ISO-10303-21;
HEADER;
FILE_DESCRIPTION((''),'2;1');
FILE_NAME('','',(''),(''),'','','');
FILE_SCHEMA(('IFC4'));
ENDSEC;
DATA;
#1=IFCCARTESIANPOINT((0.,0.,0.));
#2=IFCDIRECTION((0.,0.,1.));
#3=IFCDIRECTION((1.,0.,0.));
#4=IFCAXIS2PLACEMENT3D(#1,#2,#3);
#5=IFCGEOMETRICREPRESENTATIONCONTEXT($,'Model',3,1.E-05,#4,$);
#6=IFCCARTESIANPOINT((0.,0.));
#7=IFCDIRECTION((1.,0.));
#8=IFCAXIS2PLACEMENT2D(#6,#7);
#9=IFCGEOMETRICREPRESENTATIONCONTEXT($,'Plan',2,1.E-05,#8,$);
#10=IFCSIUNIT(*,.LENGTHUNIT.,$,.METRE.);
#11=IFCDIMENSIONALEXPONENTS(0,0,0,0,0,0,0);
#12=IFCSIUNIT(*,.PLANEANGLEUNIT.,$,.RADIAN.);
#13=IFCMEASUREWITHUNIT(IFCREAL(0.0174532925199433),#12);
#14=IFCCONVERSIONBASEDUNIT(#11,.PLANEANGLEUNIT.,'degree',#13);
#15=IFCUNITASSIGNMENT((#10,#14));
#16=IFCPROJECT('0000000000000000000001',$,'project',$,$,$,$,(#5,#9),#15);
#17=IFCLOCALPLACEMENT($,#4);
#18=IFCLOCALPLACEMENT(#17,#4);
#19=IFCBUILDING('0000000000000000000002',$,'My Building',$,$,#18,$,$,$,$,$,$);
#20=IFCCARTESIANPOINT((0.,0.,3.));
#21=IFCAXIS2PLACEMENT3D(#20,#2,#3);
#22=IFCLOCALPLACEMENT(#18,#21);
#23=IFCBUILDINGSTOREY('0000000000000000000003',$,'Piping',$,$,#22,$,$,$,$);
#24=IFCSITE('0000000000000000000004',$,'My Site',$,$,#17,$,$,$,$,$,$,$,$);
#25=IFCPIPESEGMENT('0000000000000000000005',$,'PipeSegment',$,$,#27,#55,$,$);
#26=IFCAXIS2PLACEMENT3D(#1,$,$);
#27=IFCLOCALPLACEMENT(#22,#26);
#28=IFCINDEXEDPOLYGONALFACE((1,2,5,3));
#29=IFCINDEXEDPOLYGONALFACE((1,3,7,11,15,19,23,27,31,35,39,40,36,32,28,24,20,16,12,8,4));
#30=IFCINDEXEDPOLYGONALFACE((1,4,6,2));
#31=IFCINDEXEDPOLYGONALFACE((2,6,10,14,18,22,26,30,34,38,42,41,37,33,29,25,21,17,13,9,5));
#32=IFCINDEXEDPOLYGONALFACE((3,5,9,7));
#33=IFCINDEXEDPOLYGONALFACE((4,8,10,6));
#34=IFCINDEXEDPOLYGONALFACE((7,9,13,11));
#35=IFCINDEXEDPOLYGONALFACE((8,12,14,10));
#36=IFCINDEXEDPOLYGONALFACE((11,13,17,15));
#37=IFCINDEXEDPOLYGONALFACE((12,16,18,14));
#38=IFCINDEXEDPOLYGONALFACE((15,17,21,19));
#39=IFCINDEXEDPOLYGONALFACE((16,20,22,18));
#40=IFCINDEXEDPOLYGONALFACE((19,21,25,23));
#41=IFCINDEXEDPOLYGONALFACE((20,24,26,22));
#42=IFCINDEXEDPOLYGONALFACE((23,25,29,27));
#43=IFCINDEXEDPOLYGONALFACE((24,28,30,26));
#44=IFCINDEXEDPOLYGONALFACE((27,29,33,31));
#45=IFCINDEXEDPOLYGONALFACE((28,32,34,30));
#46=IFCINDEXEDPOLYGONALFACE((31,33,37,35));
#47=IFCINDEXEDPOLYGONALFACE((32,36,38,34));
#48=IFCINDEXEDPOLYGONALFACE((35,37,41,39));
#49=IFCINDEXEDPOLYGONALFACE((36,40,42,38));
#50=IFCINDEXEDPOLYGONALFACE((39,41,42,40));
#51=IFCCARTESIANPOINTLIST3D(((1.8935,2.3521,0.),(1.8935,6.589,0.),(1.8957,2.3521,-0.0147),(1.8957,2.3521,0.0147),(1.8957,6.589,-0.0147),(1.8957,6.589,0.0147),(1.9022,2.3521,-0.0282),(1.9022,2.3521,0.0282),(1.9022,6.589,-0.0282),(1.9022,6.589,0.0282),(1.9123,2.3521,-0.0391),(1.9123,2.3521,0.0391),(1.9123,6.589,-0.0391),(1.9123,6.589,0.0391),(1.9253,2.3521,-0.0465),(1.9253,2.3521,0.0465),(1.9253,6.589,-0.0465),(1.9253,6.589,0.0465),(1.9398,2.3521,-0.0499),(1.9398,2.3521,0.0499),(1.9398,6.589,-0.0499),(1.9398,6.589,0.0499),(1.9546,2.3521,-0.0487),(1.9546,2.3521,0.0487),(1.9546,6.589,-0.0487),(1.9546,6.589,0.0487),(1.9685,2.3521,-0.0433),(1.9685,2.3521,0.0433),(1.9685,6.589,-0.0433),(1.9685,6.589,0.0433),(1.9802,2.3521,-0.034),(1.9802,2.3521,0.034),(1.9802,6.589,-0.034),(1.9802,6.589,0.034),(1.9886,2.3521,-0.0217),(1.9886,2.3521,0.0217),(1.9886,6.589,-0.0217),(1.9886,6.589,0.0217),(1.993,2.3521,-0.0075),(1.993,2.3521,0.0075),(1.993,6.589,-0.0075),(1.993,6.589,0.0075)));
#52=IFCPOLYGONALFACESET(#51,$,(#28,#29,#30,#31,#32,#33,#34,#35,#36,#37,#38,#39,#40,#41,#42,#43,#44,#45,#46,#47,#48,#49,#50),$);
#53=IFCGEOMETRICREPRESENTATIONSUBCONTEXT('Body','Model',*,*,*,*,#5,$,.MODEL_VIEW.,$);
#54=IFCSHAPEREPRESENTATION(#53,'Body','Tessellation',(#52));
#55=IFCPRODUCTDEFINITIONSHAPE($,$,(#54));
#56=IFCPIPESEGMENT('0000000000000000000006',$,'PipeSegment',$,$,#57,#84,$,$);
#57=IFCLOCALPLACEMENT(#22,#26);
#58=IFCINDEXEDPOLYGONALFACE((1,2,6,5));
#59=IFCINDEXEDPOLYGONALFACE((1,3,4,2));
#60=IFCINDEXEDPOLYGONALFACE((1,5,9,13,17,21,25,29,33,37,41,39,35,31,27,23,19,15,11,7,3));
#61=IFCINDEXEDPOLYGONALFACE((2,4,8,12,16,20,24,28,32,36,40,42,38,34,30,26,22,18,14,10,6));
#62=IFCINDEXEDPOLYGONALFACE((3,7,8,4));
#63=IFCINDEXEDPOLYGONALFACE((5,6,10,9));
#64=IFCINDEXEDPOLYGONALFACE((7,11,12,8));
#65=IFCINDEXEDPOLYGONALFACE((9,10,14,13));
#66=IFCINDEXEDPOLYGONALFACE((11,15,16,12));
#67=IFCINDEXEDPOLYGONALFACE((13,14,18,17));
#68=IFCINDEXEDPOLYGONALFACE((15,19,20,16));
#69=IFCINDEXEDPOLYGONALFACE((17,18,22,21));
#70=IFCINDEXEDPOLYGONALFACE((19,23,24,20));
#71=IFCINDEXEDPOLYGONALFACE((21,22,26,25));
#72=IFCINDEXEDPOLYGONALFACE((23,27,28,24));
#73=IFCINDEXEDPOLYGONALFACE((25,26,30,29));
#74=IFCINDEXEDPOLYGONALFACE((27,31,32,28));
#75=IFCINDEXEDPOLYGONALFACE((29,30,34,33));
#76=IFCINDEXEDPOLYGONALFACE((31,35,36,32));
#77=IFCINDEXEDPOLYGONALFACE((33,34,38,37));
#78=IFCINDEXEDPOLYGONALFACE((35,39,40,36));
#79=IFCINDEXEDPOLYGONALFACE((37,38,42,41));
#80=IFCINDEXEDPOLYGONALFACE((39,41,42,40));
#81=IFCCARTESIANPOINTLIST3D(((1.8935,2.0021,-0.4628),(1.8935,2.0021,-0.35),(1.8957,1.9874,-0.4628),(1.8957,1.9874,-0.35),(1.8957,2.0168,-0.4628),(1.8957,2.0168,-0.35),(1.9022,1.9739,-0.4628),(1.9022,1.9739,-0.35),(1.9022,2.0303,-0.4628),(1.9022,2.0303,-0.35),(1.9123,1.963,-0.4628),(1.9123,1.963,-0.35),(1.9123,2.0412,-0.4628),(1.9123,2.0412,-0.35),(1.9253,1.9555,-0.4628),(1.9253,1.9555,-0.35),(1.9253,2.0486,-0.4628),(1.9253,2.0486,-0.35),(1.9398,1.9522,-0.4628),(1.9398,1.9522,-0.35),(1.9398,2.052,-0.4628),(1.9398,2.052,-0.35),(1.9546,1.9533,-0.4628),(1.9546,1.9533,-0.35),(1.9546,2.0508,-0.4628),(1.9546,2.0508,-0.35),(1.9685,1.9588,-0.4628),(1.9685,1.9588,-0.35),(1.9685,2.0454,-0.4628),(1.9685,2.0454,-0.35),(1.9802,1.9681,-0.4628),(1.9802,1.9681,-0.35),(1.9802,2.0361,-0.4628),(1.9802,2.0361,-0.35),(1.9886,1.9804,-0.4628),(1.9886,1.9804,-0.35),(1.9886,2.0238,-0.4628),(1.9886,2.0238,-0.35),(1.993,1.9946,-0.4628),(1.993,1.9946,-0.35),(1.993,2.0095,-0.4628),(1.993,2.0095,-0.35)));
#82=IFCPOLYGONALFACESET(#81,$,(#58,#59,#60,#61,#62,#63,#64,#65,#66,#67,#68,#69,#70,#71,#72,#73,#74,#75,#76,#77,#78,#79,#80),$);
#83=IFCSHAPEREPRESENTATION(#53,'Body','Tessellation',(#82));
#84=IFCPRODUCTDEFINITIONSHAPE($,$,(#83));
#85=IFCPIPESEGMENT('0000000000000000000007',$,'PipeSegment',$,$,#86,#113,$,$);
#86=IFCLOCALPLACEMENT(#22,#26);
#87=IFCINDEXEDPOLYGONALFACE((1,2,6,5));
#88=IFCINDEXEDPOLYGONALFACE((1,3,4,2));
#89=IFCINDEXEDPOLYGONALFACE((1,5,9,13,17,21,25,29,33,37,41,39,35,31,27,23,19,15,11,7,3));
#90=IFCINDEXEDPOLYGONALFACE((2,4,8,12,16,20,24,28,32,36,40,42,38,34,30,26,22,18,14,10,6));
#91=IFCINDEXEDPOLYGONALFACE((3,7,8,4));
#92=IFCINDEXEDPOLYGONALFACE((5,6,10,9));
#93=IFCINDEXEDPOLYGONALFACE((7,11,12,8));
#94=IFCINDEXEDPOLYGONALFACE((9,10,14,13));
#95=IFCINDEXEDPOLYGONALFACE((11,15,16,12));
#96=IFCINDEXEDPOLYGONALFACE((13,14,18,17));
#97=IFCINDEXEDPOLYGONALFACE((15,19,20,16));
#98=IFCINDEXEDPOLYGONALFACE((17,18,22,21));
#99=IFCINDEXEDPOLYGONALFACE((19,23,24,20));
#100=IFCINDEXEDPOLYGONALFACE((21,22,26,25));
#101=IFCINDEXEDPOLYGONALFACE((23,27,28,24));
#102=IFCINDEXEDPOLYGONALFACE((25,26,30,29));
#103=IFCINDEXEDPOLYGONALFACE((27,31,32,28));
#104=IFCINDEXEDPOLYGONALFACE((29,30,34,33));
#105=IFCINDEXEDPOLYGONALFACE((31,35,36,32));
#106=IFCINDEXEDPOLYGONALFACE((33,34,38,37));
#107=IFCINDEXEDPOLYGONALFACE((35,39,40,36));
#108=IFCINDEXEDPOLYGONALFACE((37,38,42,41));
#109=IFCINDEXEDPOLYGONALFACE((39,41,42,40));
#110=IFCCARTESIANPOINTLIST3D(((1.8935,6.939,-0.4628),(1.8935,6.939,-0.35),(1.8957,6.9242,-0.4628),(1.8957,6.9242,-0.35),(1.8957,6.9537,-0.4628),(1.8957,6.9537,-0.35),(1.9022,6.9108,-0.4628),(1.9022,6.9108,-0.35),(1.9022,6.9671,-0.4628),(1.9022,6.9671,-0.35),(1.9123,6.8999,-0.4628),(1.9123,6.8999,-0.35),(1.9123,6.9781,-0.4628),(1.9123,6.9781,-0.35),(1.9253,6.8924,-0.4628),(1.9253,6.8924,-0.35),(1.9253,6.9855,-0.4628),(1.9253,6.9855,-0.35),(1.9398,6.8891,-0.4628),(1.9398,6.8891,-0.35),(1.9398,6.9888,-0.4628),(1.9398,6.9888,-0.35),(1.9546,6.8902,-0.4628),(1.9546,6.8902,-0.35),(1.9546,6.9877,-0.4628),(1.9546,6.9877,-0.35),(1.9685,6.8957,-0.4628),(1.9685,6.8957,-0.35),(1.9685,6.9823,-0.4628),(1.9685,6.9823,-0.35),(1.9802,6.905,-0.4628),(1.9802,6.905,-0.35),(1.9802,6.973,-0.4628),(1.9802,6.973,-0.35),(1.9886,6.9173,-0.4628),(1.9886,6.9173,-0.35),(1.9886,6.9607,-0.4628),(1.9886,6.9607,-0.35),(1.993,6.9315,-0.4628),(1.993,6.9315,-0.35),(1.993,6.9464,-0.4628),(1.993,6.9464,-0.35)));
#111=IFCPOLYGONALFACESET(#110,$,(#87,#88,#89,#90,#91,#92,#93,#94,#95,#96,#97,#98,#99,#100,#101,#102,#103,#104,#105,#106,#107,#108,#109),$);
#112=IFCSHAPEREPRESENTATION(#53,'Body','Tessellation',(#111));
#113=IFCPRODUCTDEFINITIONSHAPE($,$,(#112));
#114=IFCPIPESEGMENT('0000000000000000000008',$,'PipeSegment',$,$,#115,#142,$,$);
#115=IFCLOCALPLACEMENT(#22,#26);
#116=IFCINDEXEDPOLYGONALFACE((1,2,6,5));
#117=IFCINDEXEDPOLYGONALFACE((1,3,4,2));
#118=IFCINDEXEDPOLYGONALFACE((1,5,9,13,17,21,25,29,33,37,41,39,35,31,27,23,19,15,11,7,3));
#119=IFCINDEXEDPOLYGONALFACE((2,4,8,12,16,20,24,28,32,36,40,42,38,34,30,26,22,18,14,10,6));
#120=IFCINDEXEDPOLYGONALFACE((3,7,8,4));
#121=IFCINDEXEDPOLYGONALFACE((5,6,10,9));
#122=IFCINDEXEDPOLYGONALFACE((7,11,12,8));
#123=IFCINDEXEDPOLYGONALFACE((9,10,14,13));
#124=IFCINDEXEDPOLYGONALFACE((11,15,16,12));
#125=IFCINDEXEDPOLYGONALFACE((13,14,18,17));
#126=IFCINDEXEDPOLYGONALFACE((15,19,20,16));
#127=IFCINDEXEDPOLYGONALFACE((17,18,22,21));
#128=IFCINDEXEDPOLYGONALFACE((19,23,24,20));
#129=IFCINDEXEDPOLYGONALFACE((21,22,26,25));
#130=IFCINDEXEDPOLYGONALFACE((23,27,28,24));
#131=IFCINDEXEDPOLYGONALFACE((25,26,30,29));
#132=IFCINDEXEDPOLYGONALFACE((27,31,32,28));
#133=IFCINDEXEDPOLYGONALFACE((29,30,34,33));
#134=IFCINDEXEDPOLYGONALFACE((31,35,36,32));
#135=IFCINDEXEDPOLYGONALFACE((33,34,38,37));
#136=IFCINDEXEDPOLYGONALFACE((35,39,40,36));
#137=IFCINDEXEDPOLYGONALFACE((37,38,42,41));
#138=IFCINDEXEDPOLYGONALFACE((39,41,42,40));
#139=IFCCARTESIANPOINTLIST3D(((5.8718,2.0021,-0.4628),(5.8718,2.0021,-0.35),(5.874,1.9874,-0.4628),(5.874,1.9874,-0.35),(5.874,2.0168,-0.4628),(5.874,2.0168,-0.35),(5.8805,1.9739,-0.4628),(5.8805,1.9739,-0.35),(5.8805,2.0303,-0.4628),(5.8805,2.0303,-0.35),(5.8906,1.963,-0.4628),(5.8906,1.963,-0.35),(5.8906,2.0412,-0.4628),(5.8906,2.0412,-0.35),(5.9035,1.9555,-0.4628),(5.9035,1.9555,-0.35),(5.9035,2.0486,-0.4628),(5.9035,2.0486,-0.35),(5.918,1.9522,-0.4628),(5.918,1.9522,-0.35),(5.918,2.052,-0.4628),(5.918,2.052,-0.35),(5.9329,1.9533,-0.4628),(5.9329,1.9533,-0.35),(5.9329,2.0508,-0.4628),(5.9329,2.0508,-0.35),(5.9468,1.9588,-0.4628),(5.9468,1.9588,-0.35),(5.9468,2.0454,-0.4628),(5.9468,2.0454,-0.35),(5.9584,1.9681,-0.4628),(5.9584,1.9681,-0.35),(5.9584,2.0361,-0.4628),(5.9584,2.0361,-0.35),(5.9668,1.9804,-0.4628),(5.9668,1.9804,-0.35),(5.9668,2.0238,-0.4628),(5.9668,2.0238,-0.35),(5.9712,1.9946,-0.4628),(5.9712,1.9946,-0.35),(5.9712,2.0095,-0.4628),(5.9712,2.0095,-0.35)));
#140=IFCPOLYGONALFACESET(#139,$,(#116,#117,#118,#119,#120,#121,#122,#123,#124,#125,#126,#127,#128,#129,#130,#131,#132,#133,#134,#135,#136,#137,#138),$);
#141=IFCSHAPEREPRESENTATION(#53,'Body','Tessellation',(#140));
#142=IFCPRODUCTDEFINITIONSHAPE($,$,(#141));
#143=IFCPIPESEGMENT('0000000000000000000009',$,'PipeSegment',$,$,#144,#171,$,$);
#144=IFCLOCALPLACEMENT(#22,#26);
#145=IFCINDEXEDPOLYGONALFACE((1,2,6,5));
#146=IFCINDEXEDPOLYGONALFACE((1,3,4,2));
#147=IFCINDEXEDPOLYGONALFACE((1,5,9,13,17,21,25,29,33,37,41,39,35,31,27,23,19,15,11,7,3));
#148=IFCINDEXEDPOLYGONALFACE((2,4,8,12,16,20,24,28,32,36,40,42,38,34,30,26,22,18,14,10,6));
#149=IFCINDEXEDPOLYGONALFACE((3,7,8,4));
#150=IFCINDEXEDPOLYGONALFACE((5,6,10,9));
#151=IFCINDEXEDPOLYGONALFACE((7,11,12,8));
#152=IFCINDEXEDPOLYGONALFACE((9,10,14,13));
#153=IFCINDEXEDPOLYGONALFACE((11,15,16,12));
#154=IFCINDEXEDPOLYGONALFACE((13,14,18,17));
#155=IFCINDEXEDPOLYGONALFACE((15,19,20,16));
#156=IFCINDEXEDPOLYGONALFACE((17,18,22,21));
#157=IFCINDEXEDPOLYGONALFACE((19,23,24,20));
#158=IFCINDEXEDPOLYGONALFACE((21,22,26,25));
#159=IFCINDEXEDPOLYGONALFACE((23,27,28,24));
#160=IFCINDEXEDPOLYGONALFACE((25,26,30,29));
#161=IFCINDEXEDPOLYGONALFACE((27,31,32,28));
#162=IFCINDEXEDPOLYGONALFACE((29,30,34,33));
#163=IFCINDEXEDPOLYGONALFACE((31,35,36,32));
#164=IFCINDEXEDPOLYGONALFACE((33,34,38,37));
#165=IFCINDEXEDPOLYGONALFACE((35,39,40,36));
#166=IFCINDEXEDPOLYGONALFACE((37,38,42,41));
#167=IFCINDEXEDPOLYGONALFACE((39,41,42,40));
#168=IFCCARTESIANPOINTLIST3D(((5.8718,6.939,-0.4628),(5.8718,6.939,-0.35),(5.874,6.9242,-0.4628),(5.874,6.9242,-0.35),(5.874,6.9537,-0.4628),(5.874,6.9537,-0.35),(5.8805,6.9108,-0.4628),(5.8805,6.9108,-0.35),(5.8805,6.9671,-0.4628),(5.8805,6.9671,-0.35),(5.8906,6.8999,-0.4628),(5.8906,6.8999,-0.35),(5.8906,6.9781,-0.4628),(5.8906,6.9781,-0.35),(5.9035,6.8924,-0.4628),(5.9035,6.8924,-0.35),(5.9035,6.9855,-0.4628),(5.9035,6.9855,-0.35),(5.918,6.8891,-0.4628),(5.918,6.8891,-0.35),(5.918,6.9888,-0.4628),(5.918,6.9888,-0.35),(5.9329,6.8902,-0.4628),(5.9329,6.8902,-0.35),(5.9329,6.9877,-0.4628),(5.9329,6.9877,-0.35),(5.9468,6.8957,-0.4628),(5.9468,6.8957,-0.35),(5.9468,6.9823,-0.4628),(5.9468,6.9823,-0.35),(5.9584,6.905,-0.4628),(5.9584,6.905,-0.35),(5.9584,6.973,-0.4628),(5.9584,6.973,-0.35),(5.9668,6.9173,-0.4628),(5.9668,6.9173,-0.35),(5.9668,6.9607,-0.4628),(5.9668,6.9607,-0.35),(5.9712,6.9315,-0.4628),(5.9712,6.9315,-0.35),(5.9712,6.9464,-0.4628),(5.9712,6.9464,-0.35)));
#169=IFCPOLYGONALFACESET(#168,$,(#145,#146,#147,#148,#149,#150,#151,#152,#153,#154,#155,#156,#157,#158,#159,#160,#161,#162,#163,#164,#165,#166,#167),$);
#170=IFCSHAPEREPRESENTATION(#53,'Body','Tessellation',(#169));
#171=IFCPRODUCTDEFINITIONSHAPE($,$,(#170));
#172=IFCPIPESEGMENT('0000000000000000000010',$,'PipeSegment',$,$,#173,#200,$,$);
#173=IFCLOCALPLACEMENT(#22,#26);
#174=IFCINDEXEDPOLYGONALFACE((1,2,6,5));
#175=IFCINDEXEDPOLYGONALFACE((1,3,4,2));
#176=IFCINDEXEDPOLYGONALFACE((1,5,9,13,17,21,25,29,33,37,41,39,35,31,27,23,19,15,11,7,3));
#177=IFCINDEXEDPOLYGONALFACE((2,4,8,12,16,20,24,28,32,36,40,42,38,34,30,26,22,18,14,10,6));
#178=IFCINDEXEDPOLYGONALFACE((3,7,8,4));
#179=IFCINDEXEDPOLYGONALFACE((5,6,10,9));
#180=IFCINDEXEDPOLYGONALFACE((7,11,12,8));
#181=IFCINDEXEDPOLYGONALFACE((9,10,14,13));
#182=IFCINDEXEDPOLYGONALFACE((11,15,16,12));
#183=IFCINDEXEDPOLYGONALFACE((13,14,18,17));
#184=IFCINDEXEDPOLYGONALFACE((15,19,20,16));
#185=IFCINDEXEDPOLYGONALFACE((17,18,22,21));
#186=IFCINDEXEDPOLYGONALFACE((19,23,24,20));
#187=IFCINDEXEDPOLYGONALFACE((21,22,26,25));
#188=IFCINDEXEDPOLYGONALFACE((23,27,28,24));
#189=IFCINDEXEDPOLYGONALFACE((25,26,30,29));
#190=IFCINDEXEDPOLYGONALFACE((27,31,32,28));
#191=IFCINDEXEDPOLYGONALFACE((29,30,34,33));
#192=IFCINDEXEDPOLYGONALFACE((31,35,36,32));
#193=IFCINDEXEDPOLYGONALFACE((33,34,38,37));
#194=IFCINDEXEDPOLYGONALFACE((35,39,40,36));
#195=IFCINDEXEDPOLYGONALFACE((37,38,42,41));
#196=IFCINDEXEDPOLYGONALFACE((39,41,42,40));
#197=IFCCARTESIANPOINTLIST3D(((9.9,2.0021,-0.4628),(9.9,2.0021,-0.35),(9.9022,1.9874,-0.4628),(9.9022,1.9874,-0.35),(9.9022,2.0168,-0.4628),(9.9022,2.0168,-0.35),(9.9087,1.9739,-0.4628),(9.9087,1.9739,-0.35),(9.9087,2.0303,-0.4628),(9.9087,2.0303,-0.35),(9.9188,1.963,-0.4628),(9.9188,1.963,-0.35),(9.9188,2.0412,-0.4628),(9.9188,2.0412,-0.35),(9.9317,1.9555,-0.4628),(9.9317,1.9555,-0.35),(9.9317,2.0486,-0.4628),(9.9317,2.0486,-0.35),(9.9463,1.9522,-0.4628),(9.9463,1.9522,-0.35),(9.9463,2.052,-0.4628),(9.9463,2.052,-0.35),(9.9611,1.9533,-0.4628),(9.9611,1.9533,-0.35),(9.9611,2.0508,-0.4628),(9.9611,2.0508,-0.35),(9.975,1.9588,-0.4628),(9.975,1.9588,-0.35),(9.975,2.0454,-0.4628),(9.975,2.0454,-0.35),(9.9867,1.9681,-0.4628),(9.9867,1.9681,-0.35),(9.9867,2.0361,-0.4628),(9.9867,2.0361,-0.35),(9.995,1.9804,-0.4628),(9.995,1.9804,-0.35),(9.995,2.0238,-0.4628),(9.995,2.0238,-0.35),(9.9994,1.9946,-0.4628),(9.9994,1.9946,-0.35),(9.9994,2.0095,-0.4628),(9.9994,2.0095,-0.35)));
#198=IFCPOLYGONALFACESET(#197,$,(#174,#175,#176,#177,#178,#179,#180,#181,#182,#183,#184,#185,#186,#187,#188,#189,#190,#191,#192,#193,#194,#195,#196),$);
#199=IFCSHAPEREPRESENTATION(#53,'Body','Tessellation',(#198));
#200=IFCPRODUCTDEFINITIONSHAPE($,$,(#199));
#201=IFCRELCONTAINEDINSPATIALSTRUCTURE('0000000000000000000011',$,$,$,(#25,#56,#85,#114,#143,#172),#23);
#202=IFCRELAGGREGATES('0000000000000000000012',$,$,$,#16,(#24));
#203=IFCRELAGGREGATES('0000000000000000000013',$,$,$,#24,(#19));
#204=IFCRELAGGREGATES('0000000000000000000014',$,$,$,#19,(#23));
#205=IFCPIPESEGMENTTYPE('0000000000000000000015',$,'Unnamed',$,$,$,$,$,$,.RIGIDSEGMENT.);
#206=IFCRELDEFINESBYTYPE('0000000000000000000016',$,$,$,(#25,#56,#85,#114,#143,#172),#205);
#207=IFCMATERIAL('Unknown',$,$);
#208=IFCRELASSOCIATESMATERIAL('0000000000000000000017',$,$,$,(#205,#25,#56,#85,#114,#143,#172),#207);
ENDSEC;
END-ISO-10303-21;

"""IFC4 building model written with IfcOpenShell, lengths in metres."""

from ifc_helpers import new_model, entity, si_unit, converted_unit, frame, origin_with_axes, origin_2d_with_axis, place, context, subcontext, project, spatial, circle, extrude, material, material_profile, profile_set, profile_usage, type_object, element, save


model = new_model("IFC4")

# Units and contexts
model_context = context("Model", 3, precision=1e-05, world=origin_with_axes())
plan_context = context("Plan", 2, precision=1e-05, world=origin_2d_with_axis())
body_context = subcontext(model_context, "Body", "Model", "MODEL_VIEW")
ifc_project = project(units=[si_unit("LENGTHUNIT", "METRE"), converted_unit("PLANEANGLEUNIT", "degree", entity("IfcReal", 0.0174532925199433), si_unit("PLANEANGLEUNIT", "RADIAN"), dimensions=[0, 0, 0, 0, 0, 0, 0])], contexts=[model_context, plan_context])

# Site, building, storey
site_placement = place(None, origin_with_axes())
site = spatial("IfcSite", under=ifc_project, at=site_placement, Name="My Site")
building_placement = place(site_placement, origin_with_axes())
building = spatial("IfcBuilding", under=site, at=building_placement, Name="My Building")
storey_placement = place(building_placement, frame((0.0, 0.0, 3.0), z_axis=(0.0, 0.0, 1.0), x_axis=(1.0, 0.0, 0.0)))
storey = spatial("IfcBuildingStorey", under=building, at=storey_placement, Name="Piping")

# Pipe segments
ifc_material = material(Name="Unknown")
ifc_material_profile_1 = material_profile(ifc_material, circle(Radius=0.05))
ifc_profile_set_1 = profile_set([ifc_material_profile_1])
ifc_profile_usage_1 = profile_usage(ifc_profile_set_1, cardinal=5)
pipe_segment_type = type_object("IfcPipeSegmentType", Name="Unnamed", PredefinedType="RIGIDSEGMENT", material=ifc_profile_set_1)
pipe_segment_1_placement = place(storey_placement, frame((1.9435, 2.3521, 0.0), z_axis=(0.0, 1.0, 0.0), x_axis=(-1.0, 0.0, 0.0)))
element("IfcPipeSegment", 1, at=pipe_segment_1_placement, inside=storey, type_object=pipe_segment_type, material=ifc_profile_usage_1, Name="PipeSegment", context=body_context, shape_type="SweptSolid", body=[
    extrude(circle(Radius=0.05), origin_with_axes(), (0.0, 0.0, 1.0), 4.2369),
])
ifc_profile_usage_2 = profile_usage(ifc_profile_set_1, cardinal=5)
pipe_segment_2_placement = place(storey_placement, frame((1.9435, 2.0021, -0.35), z_axis=(0.0, 0.0, -1.0), x_axis=(-1.0, 0.0, 0.0)))
element("IfcPipeSegment", 2, at=pipe_segment_2_placement, inside=storey, type_object=pipe_segment_type, material=ifc_profile_usage_2, Name="PipeSegment", context=body_context, shape_type="SweptSolid", body=[
    extrude(circle(Radius=0.05), origin_with_axes(), (0.0, 0.0, 1.0), 0.1128),
])
ifc_profile_usage_3 = profile_usage(ifc_profile_set_1, cardinal=5)
pipe_segment_3_placement = place(storey_placement, frame((1.9435, 6.939, -0.35), z_axis=(0.0, 0.0, -1.0), x_axis=(-1.0, 0.0, 0.0)))
element("IfcPipeSegment", 3, at=pipe_segment_3_placement, inside=storey, type_object=pipe_segment_type, material=ifc_profile_usage_3, Name="PipeSegment", context=body_context, shape_type="SweptSolid", body=[
    extrude(circle(Radius=0.05), origin_with_axes(), (0.0, 0.0, 1.0), 0.1128),
])
ifc_profile_usage_4 = profile_usage(ifc_profile_set_1, cardinal=5)
pipe_segment_4_placement = place(storey_placement, frame((5.9218, 2.0021, -0.35), z_axis=(0.0, 0.0, -1.0), x_axis=(-1.0, 0.0, 0.0)))
element("IfcPipeSegment", 4, at=pipe_segment_4_placement, inside=storey, type_object=pipe_segment_type, material=ifc_profile_usage_4, Name="PipeSegment", context=body_context, shape_type="SweptSolid", body=[
    extrude(circle(Radius=0.05), origin_with_axes(), (0.0, 0.0, 1.0), 0.1128),
])
ifc_profile_usage_5 = profile_usage(ifc_profile_set_1, cardinal=5)
pipe_segment_5_placement = place(storey_placement, frame((5.9218, 6.939, -0.35), z_axis=(0.0, 0.0, -1.0), x_axis=(-1.0, 0.0, 0.0)))
element("IfcPipeSegment", 5, at=pipe_segment_5_placement, inside=storey, type_object=pipe_segment_type, material=ifc_profile_usage_5, Name="PipeSegment", context=body_context, shape_type="SweptSolid", body=[
    extrude(circle(Radius=0.05), origin_with_axes(), (0.0, 0.0, 1.0), 0.1128),
])
ifc_profile_usage_6 = profile_usage(ifc_profile_set_1, cardinal=5)
pipe_segment_6_placement = place(storey_placement, frame((9.95, 2.0021, -0.35), z_axis=(0.0, 0.0, -1.0), x_axis=(-1.0, 0.0, 0.0)))
element("IfcPipeSegment", 6, at=pipe_segment_6_placement, inside=storey, type_object=pipe_segment_type, material=ifc_profile_usage_6, Name="PipeSegment", context=body_context, shape_type="SweptSolid", body=[
    extrude(circle(Radius=0.05), origin_with_axes(), (0.0, 0.0, 1.0), 0.1128),
])

save(model, "model.ifc")
